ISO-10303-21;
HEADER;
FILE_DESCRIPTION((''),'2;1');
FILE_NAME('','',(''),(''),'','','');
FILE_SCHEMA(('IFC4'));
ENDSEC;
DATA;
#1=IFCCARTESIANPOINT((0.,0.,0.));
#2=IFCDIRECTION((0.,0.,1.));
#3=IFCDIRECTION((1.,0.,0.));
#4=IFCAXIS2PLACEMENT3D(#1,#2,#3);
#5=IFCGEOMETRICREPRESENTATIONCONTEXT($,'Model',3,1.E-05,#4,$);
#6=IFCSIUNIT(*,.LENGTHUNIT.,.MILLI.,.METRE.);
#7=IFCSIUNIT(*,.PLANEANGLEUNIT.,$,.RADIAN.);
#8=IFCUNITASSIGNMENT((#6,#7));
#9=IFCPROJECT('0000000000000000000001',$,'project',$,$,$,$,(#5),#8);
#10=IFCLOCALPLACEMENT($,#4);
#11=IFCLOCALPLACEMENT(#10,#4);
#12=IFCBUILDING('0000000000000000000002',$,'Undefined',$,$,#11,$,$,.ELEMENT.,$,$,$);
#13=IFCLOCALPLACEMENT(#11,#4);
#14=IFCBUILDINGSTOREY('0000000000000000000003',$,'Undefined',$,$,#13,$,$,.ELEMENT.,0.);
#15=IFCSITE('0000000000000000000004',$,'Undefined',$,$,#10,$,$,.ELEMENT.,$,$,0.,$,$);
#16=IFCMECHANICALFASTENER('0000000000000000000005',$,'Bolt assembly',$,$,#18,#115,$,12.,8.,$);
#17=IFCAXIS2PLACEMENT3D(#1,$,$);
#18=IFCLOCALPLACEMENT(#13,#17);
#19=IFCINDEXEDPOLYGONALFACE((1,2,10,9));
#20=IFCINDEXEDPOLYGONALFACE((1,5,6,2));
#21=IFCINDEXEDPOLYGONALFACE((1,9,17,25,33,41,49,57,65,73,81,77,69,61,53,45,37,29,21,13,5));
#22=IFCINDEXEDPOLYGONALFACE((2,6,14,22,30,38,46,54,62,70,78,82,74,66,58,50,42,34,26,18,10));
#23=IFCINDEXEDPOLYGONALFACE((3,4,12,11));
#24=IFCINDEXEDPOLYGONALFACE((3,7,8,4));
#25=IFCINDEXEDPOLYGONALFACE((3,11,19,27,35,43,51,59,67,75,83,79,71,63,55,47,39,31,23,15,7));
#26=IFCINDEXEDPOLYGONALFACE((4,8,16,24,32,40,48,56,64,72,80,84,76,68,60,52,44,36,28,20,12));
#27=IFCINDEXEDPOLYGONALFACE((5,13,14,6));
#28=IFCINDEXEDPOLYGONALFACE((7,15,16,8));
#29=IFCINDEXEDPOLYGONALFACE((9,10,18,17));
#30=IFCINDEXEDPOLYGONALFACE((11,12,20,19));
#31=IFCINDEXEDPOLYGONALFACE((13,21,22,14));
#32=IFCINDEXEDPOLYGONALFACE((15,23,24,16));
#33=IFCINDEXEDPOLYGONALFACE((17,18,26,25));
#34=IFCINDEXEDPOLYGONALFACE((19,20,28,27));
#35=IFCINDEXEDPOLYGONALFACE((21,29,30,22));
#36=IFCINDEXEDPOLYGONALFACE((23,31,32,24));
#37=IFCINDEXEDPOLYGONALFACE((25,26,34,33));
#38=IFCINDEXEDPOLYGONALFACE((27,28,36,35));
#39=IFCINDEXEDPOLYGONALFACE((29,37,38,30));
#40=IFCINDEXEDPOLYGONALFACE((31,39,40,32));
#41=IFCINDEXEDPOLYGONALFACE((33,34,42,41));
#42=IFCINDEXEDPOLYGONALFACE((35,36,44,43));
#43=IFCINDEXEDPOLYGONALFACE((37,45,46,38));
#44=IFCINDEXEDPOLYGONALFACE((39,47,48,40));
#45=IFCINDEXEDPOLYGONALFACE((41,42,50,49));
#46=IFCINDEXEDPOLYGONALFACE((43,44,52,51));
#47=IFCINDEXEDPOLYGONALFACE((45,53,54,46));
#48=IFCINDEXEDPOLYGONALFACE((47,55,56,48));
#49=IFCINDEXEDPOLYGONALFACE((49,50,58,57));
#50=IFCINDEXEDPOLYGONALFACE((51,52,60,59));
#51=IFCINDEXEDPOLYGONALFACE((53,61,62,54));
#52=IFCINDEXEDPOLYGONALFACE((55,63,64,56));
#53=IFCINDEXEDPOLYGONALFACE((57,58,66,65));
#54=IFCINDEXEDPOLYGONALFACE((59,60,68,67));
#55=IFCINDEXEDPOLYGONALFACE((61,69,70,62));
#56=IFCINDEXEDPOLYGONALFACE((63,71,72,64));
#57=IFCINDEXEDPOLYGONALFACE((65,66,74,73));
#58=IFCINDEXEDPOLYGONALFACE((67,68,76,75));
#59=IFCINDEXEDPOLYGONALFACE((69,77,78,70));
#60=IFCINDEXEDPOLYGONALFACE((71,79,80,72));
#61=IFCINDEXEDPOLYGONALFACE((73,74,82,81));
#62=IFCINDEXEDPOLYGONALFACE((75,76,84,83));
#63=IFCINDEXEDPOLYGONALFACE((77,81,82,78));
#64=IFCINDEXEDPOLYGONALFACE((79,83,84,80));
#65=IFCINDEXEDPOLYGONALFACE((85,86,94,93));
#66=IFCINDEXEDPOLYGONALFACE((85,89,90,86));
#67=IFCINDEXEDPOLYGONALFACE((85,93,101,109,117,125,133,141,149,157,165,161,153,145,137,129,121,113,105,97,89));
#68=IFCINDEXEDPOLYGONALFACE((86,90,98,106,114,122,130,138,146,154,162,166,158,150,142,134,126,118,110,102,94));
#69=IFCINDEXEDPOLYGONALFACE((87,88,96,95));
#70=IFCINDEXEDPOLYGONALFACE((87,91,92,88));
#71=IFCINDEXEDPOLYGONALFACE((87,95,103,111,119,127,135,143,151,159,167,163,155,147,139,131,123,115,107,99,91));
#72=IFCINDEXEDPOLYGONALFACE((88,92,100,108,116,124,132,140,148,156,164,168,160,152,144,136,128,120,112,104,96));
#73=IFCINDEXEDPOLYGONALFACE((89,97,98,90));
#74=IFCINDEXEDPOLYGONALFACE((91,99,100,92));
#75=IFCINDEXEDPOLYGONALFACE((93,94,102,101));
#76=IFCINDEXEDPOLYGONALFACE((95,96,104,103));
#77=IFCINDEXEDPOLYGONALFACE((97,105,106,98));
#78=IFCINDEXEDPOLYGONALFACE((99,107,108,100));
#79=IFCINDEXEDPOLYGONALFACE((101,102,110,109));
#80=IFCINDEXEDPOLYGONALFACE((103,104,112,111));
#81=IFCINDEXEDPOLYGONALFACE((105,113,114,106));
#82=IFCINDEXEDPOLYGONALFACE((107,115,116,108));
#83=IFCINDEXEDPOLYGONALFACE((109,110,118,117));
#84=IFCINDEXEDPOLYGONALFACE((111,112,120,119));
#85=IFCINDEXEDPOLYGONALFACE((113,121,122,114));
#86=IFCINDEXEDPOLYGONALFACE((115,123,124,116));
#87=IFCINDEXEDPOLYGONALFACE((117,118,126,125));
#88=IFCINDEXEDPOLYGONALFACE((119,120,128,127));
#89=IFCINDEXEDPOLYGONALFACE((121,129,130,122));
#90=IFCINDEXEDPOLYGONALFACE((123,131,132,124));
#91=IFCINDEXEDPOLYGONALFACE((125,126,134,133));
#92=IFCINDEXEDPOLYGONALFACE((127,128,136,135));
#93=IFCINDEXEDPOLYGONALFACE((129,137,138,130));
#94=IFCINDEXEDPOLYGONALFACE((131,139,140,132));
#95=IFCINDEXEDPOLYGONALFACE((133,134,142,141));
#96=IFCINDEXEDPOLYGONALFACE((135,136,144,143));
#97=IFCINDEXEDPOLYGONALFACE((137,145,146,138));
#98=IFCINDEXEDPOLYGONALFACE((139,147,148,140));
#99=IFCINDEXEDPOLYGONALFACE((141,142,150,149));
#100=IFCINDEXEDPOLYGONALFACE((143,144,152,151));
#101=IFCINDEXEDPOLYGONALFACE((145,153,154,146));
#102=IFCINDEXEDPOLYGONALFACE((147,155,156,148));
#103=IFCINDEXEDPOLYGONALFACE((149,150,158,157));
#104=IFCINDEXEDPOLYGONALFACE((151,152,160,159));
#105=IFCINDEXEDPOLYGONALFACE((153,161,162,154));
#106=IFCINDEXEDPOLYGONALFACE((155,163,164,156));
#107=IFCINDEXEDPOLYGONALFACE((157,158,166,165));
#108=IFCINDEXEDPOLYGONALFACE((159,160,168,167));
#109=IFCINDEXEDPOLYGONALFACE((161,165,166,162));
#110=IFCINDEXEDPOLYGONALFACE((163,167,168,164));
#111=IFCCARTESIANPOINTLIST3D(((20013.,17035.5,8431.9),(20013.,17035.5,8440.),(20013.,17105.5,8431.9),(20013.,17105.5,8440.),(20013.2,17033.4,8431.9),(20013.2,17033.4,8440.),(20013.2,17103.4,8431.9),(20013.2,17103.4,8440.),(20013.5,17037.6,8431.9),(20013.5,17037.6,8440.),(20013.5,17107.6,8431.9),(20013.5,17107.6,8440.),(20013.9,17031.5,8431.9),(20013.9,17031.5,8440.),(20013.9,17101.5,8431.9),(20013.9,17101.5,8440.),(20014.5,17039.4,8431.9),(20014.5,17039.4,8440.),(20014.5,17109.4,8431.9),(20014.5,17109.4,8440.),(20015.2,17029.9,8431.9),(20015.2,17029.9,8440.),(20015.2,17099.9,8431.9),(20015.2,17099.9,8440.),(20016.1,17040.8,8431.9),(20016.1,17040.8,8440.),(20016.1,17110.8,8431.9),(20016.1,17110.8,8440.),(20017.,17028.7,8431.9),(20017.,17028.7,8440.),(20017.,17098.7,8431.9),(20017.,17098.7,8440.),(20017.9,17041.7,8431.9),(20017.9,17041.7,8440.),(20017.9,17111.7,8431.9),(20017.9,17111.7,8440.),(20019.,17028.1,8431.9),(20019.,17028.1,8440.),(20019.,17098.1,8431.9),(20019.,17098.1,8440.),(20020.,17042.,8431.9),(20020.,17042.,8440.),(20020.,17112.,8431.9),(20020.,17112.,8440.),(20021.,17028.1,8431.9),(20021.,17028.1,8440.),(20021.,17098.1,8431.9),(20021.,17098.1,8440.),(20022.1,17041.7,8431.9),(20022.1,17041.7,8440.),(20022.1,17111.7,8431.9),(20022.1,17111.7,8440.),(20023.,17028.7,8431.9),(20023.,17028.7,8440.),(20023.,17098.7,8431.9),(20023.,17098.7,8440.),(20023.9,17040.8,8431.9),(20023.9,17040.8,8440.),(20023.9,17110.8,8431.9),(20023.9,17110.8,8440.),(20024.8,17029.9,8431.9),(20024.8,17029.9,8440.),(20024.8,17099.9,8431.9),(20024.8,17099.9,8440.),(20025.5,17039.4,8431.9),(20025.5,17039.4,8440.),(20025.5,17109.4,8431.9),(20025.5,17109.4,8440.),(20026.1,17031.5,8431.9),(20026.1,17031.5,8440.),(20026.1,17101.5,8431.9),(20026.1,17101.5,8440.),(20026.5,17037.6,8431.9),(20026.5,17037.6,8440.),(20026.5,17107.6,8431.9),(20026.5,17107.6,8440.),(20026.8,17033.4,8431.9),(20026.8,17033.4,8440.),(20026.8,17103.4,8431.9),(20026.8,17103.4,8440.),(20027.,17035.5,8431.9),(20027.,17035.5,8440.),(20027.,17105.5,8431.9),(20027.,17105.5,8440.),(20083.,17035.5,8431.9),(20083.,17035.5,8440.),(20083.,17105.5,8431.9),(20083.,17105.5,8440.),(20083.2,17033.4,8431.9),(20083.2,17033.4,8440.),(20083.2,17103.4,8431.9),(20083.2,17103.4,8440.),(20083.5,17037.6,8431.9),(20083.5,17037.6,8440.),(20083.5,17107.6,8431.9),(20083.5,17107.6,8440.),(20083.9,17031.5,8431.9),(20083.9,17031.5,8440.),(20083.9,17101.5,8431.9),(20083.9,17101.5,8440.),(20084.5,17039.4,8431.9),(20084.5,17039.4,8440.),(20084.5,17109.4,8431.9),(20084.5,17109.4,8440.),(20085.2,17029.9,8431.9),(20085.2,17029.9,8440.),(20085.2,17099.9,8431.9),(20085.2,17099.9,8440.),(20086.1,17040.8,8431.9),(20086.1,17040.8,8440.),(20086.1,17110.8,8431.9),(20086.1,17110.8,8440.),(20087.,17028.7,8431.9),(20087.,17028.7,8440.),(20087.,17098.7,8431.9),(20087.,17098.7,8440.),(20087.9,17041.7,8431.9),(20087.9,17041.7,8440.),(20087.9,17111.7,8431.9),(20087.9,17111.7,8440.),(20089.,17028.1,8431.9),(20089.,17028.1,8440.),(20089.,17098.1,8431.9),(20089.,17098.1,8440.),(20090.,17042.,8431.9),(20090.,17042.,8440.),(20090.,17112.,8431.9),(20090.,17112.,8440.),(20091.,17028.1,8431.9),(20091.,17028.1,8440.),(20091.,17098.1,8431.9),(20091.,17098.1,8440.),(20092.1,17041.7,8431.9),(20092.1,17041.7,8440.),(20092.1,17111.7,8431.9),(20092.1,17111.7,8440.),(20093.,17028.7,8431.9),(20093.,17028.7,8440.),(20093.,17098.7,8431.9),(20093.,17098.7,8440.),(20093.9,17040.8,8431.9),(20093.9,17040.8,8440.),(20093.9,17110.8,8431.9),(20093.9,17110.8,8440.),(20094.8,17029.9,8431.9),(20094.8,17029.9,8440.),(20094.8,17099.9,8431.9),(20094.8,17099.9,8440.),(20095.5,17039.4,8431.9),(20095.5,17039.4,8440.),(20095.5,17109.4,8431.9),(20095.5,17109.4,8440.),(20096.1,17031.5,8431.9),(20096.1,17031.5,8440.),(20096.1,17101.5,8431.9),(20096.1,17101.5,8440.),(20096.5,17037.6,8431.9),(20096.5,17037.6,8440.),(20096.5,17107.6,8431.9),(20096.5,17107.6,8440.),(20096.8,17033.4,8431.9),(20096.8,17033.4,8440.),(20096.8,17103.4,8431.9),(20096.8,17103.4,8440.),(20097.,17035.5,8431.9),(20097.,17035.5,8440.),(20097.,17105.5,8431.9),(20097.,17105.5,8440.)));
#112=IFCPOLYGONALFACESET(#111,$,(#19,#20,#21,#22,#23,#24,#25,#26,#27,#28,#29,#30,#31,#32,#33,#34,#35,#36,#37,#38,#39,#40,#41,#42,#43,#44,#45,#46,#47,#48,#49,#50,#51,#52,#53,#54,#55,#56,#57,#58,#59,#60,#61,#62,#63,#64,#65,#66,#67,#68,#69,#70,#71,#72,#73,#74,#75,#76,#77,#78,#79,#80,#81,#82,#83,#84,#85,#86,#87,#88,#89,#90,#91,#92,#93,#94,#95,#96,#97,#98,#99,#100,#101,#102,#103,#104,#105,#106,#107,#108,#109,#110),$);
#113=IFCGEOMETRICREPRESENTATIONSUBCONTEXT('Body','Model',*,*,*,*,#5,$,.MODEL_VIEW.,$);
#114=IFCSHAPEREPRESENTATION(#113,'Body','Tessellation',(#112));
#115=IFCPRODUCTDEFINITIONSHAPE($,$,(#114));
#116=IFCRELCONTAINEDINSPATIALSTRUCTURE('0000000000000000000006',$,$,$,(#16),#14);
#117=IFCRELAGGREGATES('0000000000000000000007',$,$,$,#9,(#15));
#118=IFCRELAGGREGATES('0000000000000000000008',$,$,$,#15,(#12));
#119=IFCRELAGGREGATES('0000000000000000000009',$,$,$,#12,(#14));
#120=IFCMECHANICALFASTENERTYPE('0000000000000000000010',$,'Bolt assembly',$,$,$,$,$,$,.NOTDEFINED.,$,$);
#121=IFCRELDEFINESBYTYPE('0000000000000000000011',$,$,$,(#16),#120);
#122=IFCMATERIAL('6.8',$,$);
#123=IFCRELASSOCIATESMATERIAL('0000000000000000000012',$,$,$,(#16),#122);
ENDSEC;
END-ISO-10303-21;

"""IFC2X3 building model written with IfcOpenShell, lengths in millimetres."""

from ifc_helpers import new_model, si_unit, frame, origin_with_axes, origin_2d_with_axis, place, context, subcontext, project, spatial, circle, extrude, source, transform, mapped, material, type_object, element, save


model = new_model("IFC2X3")

# Units and contexts
model_context = context("Model", 3, precision=1e-05, world=origin_with_axes())
body_context = subcontext(model_context, "Body", "Model", "MODEL_VIEW")
ifc_project = project(units=[si_unit("LENGTHUNIT", "METRE", prefix="MILLI"), si_unit("PLANEANGLEUNIT", "RADIAN")], contexts=[model_context])

# Site, building, storey
site_placement = place(None, origin_with_axes())
site = spatial("IfcSite", under=ifc_project, at=site_placement, Name="Undefined", CompositionType="ELEMENT", RefElevation=0.0)
building_placement = place(site_placement, origin_with_axes())
building = spatial("IfcBuilding", under=site, at=building_placement, Name="Undefined", CompositionType="ELEMENT")
storey_placement = place(building_placement, origin_with_axes())
storey = spatial("IfcBuildingStorey", under=building, at=storey_placement, Name="Undefined", CompositionType="ELEMENT", Elevation=0.0)

# Mechanical fastener
ifc_material_1 = material(Name="6.8")
mechanical_fastener_type = type_object("IfcMechanicalFastenerType", Name="Bolt assembly")
shared_shape_1 = source(origin_with_axes(), body_context, "Body", "SweptSolid", [
    extrude(circle(Radius=7.0, at=origin_2d_with_axis()), frame((0.0, 0.0, 0.0), z_axis=(0.0, 1.0, 0.0), x_axis=(1.0, 0.0, 0.0)), (0.0, 0.0, 1.0), 8.1),
])
mechanical_fastener_1_placement = place(storey_placement, frame((20055.0, 17035.0, 8440.0), z_axis=(-1.0, 0.0, 0.0), x_axis=(0.0, 1.0, 0.0)))
element("IfcMechanicalFastener", 1, at=mechanical_fastener_1_placement, inside=storey, type_object=mechanical_fastener_type, material=ifc_material_1, Name="Bolt assembly", NominalDiameter=12.0, NominalLength=8.0, context=body_context, shape_type="MappedRepresentation", body=[
    mapped(shared_shape_1, transform((0.0, 0.0, -35.0))),
    mapped(shared_shape_1, transform((70.0, 0.0, -35.0))),
    mapped(shared_shape_1, transform((0.0, 0.0, 35.0))),
    mapped(shared_shape_1, transform((70.0, 0.0, 35.0))),
])

save(model, "model.ifc")
